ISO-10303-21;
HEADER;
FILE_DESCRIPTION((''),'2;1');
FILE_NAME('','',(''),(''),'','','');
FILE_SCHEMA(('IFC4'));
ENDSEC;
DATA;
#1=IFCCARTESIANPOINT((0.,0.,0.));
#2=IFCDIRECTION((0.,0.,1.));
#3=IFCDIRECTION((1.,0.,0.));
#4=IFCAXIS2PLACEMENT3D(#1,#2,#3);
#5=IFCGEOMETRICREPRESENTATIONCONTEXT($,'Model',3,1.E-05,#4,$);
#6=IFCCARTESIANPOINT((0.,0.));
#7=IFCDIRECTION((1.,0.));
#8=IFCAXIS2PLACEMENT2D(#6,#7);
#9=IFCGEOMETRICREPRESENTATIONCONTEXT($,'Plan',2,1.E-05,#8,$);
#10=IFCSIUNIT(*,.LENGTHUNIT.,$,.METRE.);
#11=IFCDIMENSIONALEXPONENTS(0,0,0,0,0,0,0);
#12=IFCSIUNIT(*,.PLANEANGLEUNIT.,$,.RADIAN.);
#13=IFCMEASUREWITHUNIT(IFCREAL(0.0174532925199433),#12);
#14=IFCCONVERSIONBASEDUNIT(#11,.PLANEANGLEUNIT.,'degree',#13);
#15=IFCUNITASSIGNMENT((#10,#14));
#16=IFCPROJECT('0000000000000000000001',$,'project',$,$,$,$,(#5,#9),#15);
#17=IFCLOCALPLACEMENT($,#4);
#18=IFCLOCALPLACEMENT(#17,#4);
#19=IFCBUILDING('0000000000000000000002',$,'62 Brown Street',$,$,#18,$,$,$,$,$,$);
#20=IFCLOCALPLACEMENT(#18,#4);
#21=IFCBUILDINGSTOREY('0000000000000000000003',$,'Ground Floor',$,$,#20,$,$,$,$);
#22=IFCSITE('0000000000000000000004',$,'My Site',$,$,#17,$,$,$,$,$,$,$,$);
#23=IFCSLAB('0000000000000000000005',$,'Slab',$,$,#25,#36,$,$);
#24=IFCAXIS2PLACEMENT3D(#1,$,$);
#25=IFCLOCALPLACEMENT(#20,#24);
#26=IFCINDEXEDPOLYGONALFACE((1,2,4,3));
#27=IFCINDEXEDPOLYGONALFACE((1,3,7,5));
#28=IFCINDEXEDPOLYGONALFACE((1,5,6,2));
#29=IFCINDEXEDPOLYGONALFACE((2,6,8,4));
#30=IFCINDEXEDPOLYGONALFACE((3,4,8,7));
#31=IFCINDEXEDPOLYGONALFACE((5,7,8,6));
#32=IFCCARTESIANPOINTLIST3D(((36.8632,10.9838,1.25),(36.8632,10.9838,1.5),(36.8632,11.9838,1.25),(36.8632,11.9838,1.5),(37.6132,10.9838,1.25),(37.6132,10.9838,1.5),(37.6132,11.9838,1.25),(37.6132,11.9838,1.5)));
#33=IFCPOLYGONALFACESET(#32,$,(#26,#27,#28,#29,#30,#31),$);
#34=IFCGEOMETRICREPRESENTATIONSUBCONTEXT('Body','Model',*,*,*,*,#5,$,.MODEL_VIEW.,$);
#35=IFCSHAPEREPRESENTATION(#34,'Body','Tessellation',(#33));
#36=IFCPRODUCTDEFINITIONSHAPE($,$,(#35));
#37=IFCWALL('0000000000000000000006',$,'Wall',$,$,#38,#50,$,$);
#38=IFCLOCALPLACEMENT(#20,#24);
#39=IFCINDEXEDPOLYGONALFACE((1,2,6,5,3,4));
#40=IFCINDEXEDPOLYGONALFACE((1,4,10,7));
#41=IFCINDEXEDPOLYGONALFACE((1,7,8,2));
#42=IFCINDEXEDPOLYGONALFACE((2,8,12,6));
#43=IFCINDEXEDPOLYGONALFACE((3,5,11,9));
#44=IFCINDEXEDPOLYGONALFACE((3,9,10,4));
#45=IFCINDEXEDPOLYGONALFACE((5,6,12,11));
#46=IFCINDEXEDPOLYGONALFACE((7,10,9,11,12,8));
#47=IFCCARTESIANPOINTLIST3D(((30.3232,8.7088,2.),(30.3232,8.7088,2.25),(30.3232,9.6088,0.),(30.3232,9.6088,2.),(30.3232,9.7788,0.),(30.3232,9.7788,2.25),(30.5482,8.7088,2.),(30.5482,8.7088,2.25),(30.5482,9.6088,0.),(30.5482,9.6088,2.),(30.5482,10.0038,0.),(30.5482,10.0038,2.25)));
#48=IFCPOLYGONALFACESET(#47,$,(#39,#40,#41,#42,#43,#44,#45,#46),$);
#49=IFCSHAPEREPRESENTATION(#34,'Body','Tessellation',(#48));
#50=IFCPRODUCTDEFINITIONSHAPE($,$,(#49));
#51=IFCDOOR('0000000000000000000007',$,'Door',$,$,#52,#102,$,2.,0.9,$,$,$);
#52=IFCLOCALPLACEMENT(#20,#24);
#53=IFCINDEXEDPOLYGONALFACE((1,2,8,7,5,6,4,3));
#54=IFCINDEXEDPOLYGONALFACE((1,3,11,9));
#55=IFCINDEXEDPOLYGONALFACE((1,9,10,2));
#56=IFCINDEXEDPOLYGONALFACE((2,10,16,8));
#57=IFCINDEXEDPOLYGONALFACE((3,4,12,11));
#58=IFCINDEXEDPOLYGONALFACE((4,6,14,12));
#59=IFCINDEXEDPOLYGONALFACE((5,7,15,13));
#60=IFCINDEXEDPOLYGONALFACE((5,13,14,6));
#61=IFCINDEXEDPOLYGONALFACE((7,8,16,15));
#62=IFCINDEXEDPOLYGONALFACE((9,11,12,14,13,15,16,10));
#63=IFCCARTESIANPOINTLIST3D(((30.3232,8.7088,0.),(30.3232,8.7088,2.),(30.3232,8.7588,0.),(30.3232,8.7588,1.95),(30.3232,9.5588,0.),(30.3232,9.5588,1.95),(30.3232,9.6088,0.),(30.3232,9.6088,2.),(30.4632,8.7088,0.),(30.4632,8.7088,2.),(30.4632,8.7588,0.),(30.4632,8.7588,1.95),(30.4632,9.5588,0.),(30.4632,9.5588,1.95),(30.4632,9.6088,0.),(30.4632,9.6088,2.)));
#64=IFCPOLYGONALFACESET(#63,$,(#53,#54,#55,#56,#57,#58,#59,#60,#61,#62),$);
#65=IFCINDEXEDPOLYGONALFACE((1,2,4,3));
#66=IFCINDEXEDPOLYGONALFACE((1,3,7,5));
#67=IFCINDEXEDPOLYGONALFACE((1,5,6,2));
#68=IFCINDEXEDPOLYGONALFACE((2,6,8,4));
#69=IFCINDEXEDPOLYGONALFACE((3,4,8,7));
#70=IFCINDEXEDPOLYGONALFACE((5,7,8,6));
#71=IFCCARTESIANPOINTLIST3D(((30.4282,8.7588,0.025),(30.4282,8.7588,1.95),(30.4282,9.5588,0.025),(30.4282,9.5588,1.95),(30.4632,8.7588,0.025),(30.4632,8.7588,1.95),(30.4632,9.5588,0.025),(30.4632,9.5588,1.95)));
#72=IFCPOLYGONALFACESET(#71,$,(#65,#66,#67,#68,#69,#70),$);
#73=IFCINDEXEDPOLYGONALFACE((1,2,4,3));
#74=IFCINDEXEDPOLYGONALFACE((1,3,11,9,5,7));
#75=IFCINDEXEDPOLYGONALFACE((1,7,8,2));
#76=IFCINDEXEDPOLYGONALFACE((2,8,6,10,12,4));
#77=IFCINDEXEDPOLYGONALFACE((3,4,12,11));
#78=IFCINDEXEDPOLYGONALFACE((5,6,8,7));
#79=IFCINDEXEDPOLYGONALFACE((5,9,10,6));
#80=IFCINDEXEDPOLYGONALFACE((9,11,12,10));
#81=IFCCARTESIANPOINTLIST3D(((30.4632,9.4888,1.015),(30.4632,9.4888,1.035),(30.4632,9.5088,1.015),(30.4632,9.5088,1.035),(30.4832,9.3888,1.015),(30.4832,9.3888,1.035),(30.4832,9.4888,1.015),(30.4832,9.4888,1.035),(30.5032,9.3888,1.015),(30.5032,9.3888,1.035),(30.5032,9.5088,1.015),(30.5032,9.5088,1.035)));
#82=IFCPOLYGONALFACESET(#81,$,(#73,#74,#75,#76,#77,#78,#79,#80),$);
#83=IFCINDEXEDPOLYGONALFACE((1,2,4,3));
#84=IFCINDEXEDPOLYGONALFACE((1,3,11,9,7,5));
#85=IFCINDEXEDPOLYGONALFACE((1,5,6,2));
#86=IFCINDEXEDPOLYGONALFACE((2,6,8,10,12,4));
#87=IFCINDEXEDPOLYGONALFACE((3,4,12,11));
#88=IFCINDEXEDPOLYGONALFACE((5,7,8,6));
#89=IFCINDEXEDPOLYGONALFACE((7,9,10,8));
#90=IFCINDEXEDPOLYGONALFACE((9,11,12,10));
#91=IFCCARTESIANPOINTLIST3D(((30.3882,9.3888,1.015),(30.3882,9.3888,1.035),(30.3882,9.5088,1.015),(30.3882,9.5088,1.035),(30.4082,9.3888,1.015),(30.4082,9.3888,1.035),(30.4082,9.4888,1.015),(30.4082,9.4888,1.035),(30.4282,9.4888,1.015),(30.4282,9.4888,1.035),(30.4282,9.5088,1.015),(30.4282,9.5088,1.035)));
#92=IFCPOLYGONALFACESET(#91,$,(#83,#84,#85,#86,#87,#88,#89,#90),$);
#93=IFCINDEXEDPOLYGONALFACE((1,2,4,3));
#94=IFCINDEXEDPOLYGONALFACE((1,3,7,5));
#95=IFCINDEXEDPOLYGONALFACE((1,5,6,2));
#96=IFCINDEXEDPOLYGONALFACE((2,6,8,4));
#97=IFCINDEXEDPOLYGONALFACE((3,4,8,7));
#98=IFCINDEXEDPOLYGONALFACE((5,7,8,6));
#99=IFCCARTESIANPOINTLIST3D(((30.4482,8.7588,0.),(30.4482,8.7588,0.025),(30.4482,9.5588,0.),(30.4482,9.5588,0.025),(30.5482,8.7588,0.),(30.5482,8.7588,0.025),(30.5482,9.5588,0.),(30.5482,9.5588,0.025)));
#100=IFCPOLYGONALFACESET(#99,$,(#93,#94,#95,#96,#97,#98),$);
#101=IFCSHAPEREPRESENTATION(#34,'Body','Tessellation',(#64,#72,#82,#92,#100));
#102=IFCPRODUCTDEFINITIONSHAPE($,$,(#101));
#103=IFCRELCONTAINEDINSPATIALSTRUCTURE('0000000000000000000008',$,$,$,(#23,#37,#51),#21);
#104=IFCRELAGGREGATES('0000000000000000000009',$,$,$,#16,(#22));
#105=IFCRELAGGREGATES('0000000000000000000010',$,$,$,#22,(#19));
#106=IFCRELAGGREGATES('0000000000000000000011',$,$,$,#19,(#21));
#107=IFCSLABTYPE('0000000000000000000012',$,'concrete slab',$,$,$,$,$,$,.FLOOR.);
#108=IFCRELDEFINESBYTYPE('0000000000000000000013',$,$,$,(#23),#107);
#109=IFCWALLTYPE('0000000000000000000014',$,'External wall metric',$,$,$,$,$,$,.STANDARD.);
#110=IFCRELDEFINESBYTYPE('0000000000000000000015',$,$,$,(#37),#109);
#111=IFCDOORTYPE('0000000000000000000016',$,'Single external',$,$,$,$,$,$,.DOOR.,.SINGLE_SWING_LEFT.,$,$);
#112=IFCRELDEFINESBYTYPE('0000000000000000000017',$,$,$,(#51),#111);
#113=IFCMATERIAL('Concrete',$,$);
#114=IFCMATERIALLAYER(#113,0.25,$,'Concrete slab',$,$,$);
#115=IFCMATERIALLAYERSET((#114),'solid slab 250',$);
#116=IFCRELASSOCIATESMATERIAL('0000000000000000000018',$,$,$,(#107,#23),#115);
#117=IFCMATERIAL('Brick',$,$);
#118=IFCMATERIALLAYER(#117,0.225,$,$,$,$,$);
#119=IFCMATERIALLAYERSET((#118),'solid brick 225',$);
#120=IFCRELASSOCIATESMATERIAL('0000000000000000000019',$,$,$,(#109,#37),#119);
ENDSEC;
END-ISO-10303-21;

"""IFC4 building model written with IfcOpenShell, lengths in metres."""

from ifc_helpers import new_model, entity, si_unit, converted_unit, frame, origin_with_axes, origin_2d_with_axis, place, context, subcontext, project, spatial, line, indexed_curve, outline, extrude, clip, halfspace, shape, source, transform, mapped, material, layer, layer_set, layer_usage, type_object, type_shapes, element, fill, save


model = new_model("IFC4")

# Units and contexts
model_context = context("Model", 3, precision=1e-05, world=origin_with_axes())
plan_context = context("Plan", 2, precision=1e-05, world=origin_2d_with_axis())
body_context_1 = subcontext(model_context, "Body", "Model", "MODEL_VIEW")
body_context_2 = subcontext(plan_context, "Body", "Plan", "PLAN_VIEW")
ifc_project = project(units=[si_unit("LENGTHUNIT", "METRE"), converted_unit("PLANEANGLEUNIT", "degree", entity("IfcReal", 0.0174532925199433), si_unit("PLANEANGLEUNIT", "RADIAN"), dimensions=[0, 0, 0, 0, 0, 0, 0])], contexts=[model_context, plan_context])

# Site, building, storey
site_placement = place(None, origin_with_axes())
site = spatial("IfcSite", under=ifc_project, at=site_placement, Name="My Site")
building_placement = place(site_placement, origin_with_axes())
building = spatial("IfcBuilding", under=site, at=building_placement, Name="62 Brown Street")
storey_placement = place(building_placement, origin_with_axes())
storey = spatial("IfcBuildingStorey", under=building, at=storey_placement, Name="Ground Floor")

# Slab
ifc_material_1 = material(Name="Concrete")
ifc_layer_1 = layer(ifc_material_1, 0.25, Name="Concrete slab")
ifc_layer_set_1 = layer_set([ifc_layer_1], Name="solid slab 250")
ifc_layer_usage_1 = layer_usage(ifc_layer_set_1, "AXIS3", "POSITIVE", 0.0)
slab_type = type_object("IfcSlabType", Name="concrete slab", PredefinedType="FLOOR", material=ifc_layer_set_1)
slab_placement = place(storey_placement, frame((36.8632, 10.9838, 1.25), z_axis=(0.0, 0.0, 1.0), x_axis=(1.0, 0.0, 0.0)))
element("IfcSlab", 1, at=slab_placement, inside=storey, type_object=slab_type, material=ifc_layer_usage_1, Name="Slab", context=body_context_1, shape_type="SweptSolid", body=[
    extrude(outline(indexed_curve([(0.0, 0.0), (0.75, 0.0), (0.75, 1.0), (0.0, 1.0)], segments=[line(4, 1), line(1, 2), line(2, 3), line(3, 4)], self_intersect=False)), None, (0.0, 0.0, 1.0), 0.25),
])

# Shared definitions
ifc_material_2 = material(Name="Brick")
ifc_layer_2 = layer(ifc_material_2, 0.225)
ifc_layer_set_2 = layer_set([ifc_layer_2], Name="solid brick 225")
wall_type_1 = type_object("IfcWallType", Name="External wall metric", PredefinedType="STANDARD", material=ifc_layer_set_2)

# Wall, opening, door
ifc_layer_usage_2 = layer_usage(ifc_layer_set_2, "AXIS2", "POSITIVE", 0.0)
wall_1_placement = place(storey_placement, frame((30.5482, 8.7088, 0.0), z_axis=(0.0, 0.0, 1.0), x_axis=(0.0, 1.0, 0.0)))
wall_1 = element("IfcWall", 2, at=wall_1_placement, inside=storey, type_object=wall_type_1, material=ifc_layer_usage_2, Name="Wall", context=body_context_1, shape_type="Clipping", body=[
    clip(extrude(outline(indexed_curve([(0.0, 0.0), (0.0, 0.225), (1.295, 0.225), (1.295, 0.0), (0.0, 0.0)], self_intersect=False)), origin_with_axes(), (0.0, 0.0, 1.0), 2.25), halfspace(frame((1.295, 0.0, 0.0), z_axis=(0.506251, 0.506251, 0.0), x_axis=(-0.225, 0.225, 0.0)), False)),
])
shared_shape_1 = source(origin_with_axes(), body_context_1, "Body", "SweptSolid", [
    extrude(outline(indexed_curve([(0.0, 0.0), (0.9, 0.0), (0.9, 2.0), (0.0, 2.0)], segments=[line(1, 2, 3, 4, 1)])), frame((0.0, -0.6, 0.0), z_axis=(0.0, -1.0, 0.0), x_axis=(1.0, 0.0, 0.0)), (0.0, 0.0, -1.0), 1.2),
])
opening_1_placement = place(wall_1_placement, frame((0.0, 0.0, 0.0), z_axis=(0.0, 0.0, 1.0), x_axis=(1.0, 0.0, 0.0)))
opening_1 = element("IfcOpeningElement", 3, at=opening_1_placement, cuts=wall_1, PredefinedType="OPENING", context=body_context_1, shape_type="MappedRepresentation", body=[
    mapped(shared_shape_1, transform((0.0, 0.0, 0.0), x_axis=(1.0, 0.0, 0.0), y_axis=(0.0, 1.0, 0.0), z_axis=(0.0, 0.0, 1.0), scale=1.0)),
])
door_type_1 = type_object("IfcDoorType", Name="Single external", OperationType="SINGLE_SWING_LEFT", PredefinedType="DOOR")
shared_shape_2 = source(origin_with_axes(), body_context_1, "Body", "SweptSolid", [
    extrude(outline(indexed_curve([(0.0, 0.0), (0.0, 2.0), (0.9, 2.0), (0.9, 0.0), (0.85, 0.0), (0.85, 1.95), (0.05, 1.95), (0.05, 0.0)], segments=[line(1, 2, 3, 4, 5, 6, 7, 8, 1)])), frame((0.0, 0.085, 0.0), z_axis=(0.0, -1.0, 0.0), x_axis=(1.0, 0.0, 0.0)), (0.0, 0.0, -1.0), 0.14),
    extrude(outline(indexed_curve([(0.0, 0.0), (0.8, 0.0), (0.8, 0.035), (0.0, 0.035)], segments=[line(1, 2, 3, 4, 1)])), frame((0.05, 0.085, 0.025), z_axis=(0.0, 0.0, 1.0), x_axis=(1.0, 0.0, 0.0)), (0.0, 0.0, 1.0), 1.925),
    extrude(outline(indexed_curve([(0.0, 0.0), (0.0, -0.04), (-0.12, -0.04), (-0.12, -0.02), (-0.02, -0.02), (-0.02, 0.0)], segments=[line(1, 2, 3, 4, 5, 6, 1)])), frame((0.8, 0.085, 1.015), z_axis=(0.0, 0.0, 1.0), x_axis=(1.0, 0.0, 0.0)), (0.0, 0.0, 1.0), 0.02),
    extrude(outline(indexed_curve([(0.0, 0.0), (0.0, 0.04), (-0.12, 0.04), (-0.12, 0.02), (-0.02, 0.02), (-0.02, 0.0)], segments=[line(1, 2, 3, 4, 5, 6, 1)])), frame((0.8, 0.12, 1.015), z_axis=(0.0, 0.0, 1.0), x_axis=(1.0, 0.0, 0.0)), (0.0, 0.0, 1.0), 0.02),
    extrude(outline(indexed_curve([(0.0, 0.0), (0.8, 0.0), (0.8, 0.1), (0.0, 0.1)], segments=[line(1, 2, 3, 4, 1)])), frame((0.05, 0.0, 0.0), z_axis=(0.0, 0.0, 1.0), x_axis=(1.0, 0.0, 0.0)), (0.0, 0.0, 1.0), 0.025),
])
shared_shape_3 = source(origin_with_axes(), body_context_2, "Body", "Curve2D", [
    entity("IfcIndexedPolyCurve", entity("IfcCartesianPointList2D", [[0.0, 0.085], [0.05, 0.085], [0.05, 0.225], [0.0, 0.225]]), [entity("IfcLineIndex", [1, 2, 3, 4, 1])]),
    entity("IfcIndexedPolyCurve", entity("IfcCartesianPointList2D", [[0.9, 0.085], [0.85, 0.085], [0.85, 0.225], [0.9, 0.225]]), [entity("IfcLineIndex", [1, 2, 3, 4, 1])]),
    entity("IfcTrimmedCurve", entity("IfcEllipse", entity("IfcAxis2Placement2D", entity("IfcCartesianPoint", [0.085, 0.225]), entity("IfcDirection", [1.0, 0.0])), 0.765, 0.8), [entity("IfcCartesianPoint", [0.85, 0.225])], [entity("IfcCartesianPoint", [0.085, 1.025])], True, "CARTESIAN"),
    entity("IfcIndexedPolyCurve", entity("IfcCartesianPointList2D", [[0.05, 0.225], [0.085, 0.225], [0.085, 1.025], [0.05, 1.025]]), [entity("IfcLineIndex", [1, 2, 3, 4, 1])]),
])
type_shapes(door_type_1, [shared_shape_2, shared_shape_3])
door_1_placement = place(opening_1_placement, frame((0.0, 0.0, 0.0), z_axis=(0.0, 0.0, 1.0), x_axis=(1.0, 0.0, 0.0)))
door_1 = element("IfcDoor", 4, at=door_1_placement, inside=storey, type_object=door_type_1, Name="Door", OverallHeight=2.0, OverallWidth=0.9, shapes=[
    shape(body_context_1, "Body", "MappedRepresentation", [mapped(shared_shape_2, transform((0.0, 0.0, 0.0), x_axis=(1.0, 0.0, 0.0), y_axis=(0.0, 1.0, 0.0), z_axis=(0.0, 0.0, 1.0), scale=1.0))]),
    shape(body_context_2, "Body", "MappedRepresentation", [mapped(shared_shape_3, transform((0.0, 0.0, 0.0), x_axis=(1.0, 0.0, 0.0), y_axis=(0.0, 1.0, 0.0), z_axis=(0.0, 0.0, 1.0), scale=1.0))]),
])
fill(opening_1, door_1)

save(model, "model.ifc")
